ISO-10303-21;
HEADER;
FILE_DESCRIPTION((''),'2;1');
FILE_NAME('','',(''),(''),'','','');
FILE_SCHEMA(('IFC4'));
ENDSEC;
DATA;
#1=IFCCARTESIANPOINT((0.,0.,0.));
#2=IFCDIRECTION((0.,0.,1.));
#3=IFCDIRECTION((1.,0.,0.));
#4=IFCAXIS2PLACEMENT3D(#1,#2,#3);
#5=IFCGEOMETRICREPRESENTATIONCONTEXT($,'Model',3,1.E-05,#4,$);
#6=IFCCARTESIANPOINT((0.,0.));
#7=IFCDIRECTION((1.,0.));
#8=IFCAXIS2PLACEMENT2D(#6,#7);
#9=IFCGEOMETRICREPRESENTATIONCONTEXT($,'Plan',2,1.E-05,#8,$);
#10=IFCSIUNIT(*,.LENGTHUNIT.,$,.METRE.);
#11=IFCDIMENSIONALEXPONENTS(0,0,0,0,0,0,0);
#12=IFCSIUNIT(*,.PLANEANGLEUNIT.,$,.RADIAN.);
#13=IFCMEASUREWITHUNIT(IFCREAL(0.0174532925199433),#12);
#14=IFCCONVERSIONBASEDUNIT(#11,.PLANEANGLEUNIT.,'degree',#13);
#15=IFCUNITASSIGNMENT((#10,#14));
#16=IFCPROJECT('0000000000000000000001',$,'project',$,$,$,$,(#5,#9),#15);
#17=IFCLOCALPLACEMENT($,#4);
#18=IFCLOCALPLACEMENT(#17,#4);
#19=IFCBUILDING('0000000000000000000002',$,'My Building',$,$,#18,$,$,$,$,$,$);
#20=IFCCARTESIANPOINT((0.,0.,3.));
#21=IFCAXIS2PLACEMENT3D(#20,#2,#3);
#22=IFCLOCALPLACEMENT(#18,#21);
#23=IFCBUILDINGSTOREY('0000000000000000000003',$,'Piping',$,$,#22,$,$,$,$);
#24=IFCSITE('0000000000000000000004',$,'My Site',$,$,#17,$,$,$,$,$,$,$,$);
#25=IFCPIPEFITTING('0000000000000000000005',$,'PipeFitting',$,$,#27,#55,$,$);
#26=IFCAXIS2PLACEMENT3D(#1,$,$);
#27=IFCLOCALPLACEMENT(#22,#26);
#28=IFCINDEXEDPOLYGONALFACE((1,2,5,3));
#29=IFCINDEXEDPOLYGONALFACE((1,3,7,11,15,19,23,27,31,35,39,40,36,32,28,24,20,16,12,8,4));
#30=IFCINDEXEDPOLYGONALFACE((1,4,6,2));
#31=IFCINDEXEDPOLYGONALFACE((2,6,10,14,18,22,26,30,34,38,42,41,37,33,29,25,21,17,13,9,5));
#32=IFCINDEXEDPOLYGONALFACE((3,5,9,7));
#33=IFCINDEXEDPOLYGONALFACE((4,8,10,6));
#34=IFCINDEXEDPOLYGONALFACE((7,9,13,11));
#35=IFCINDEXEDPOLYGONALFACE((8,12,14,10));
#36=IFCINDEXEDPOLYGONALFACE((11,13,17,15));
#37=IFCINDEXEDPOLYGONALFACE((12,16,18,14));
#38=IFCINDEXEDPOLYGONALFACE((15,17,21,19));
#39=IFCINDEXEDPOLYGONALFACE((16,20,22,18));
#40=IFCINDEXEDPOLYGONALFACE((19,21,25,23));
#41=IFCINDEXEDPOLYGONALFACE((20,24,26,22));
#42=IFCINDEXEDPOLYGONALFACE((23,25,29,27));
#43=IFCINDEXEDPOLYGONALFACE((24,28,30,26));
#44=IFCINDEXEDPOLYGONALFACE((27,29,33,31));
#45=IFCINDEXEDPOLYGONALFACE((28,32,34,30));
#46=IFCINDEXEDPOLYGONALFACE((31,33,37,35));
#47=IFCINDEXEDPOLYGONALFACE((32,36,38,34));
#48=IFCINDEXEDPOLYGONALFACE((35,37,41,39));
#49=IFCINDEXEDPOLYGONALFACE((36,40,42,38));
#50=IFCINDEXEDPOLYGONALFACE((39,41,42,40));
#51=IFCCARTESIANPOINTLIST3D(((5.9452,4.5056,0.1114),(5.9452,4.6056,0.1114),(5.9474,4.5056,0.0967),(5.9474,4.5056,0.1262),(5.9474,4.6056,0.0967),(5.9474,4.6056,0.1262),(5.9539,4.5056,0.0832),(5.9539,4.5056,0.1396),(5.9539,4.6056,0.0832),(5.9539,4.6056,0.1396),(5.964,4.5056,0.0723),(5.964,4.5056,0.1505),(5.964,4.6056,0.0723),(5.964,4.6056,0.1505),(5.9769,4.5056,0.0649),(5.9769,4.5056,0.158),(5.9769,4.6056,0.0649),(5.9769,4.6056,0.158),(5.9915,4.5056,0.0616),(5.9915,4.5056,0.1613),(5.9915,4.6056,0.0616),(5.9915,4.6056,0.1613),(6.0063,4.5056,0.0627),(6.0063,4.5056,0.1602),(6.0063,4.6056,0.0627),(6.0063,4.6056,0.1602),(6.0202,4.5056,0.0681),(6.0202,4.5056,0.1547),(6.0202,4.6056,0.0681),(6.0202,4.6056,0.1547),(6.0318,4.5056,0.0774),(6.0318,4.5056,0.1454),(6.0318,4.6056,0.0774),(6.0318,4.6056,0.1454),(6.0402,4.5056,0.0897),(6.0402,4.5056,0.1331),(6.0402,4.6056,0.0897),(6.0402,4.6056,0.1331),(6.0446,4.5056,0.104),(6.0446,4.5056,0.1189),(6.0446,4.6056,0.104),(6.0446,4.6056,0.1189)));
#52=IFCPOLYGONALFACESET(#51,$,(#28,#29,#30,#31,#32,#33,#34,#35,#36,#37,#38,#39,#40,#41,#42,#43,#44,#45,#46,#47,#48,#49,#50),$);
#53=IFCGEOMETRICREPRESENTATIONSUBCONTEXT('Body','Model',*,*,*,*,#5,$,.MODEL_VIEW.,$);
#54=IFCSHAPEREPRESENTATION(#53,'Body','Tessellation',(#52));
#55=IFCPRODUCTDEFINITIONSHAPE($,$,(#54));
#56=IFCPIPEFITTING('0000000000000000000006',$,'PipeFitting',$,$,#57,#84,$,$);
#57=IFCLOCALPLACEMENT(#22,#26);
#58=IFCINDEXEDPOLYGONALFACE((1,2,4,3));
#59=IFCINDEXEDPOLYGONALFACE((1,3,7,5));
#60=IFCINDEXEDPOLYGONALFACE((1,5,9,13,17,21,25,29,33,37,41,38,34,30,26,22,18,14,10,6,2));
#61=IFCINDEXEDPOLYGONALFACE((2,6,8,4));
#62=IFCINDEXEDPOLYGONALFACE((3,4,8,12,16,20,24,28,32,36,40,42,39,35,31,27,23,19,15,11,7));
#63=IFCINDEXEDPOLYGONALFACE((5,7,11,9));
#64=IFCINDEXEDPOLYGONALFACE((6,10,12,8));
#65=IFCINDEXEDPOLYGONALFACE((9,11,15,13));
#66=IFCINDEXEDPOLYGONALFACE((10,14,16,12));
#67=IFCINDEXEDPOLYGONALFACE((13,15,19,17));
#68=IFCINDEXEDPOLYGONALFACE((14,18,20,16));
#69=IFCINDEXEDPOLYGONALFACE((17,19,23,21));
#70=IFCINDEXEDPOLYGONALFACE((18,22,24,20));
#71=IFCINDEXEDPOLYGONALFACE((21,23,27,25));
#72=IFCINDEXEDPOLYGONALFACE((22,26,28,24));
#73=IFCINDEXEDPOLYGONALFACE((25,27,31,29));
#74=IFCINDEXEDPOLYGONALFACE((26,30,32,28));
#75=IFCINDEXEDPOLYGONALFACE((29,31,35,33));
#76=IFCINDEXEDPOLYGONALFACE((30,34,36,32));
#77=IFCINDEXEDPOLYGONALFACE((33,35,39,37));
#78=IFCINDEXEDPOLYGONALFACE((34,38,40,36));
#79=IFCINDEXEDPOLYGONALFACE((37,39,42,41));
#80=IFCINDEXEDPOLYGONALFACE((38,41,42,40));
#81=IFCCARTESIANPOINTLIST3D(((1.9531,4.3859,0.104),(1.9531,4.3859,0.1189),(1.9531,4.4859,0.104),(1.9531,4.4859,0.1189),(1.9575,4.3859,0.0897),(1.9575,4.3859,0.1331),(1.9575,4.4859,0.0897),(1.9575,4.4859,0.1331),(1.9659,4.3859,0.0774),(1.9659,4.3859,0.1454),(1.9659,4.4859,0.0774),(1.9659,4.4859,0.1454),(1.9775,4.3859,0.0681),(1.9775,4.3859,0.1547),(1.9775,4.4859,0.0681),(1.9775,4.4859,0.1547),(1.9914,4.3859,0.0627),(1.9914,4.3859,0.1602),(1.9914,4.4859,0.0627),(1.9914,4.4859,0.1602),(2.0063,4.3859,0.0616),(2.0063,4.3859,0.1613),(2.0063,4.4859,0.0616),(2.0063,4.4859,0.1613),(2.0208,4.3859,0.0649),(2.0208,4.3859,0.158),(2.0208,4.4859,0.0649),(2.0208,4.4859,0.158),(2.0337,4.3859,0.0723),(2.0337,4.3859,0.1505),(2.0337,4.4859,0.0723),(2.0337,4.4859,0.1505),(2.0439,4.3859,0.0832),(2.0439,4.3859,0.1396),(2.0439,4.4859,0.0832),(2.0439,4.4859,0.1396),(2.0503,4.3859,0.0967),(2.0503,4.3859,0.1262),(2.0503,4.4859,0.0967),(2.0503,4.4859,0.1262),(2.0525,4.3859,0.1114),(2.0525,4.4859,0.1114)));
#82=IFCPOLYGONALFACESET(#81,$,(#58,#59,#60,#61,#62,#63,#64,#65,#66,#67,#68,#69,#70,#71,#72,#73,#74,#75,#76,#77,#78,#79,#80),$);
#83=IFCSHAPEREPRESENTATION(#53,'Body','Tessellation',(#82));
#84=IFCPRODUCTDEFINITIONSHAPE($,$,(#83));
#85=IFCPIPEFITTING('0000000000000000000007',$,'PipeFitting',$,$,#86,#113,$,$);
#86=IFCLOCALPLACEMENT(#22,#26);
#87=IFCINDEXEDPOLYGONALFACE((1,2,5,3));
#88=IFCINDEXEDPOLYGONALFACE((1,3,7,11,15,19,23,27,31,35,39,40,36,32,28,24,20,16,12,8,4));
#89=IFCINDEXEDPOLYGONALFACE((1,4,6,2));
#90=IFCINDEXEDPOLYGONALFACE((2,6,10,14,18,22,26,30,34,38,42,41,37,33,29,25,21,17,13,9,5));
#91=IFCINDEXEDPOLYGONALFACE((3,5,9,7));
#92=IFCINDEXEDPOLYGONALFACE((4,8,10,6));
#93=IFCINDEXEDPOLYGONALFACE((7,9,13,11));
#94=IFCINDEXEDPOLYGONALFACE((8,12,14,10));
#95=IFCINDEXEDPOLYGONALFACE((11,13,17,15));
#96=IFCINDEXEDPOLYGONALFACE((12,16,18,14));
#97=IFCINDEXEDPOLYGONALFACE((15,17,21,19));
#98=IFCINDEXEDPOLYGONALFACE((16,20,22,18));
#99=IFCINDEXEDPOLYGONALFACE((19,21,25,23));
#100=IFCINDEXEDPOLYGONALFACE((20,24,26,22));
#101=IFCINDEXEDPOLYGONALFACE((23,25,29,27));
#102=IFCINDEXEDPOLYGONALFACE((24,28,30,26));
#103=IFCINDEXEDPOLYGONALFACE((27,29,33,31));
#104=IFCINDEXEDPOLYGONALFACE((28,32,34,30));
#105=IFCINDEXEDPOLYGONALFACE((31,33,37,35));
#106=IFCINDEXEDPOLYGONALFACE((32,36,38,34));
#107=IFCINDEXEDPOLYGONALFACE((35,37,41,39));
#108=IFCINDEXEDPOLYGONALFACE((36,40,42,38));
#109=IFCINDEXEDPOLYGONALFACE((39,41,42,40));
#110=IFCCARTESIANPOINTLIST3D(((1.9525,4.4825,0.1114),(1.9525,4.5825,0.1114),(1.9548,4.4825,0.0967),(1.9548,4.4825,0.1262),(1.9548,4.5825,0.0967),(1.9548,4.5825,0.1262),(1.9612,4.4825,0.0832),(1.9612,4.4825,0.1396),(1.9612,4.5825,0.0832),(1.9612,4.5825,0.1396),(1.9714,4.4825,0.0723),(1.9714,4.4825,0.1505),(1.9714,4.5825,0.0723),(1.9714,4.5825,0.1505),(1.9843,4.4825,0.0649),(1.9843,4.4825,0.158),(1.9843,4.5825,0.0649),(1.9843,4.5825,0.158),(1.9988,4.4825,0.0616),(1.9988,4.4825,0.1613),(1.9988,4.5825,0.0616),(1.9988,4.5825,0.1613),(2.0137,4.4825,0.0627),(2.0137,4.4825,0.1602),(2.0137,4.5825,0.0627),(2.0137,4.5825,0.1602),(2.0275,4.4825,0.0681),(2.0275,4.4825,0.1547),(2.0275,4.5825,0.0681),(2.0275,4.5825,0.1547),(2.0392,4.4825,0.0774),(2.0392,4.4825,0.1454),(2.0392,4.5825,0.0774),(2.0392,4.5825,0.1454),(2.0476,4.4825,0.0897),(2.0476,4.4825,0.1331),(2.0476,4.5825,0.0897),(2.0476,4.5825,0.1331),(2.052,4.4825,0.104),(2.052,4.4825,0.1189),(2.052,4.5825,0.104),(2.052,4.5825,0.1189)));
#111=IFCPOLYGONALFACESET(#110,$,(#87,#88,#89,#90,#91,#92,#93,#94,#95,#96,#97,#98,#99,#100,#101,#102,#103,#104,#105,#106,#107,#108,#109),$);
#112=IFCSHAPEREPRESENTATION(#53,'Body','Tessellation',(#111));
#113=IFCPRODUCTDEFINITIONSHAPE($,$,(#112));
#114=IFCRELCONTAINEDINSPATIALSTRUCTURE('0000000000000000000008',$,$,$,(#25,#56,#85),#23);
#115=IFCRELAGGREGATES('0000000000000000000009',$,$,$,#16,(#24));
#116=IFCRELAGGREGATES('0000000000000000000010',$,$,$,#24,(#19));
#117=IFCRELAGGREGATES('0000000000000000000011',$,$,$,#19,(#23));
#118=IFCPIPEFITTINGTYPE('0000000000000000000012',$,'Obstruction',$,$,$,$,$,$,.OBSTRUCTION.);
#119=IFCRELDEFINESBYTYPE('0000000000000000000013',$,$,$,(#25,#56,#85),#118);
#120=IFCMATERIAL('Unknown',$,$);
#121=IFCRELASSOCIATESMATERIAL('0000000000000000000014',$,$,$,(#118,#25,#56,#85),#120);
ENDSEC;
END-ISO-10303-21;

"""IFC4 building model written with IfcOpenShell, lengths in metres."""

from ifc_helpers import new_model, entity, si_unit, converted_unit, frame, origin_with_axes, origin_2d_with_axis, place, context, subcontext, project, spatial, circle, extrude, material, material_profile, profile_set, profile_usage, type_object, element, save


model = new_model("IFC4")

# Units and contexts
model_context = context("Model", 3, precision=1e-05, world=origin_with_axes())
plan_context = context("Plan", 2, precision=1e-05, world=origin_2d_with_axis())
body_context = subcontext(model_context, "Body", "Model", "MODEL_VIEW")
ifc_project = project(units=[si_unit("LENGTHUNIT", "METRE"), converted_unit("PLANEANGLEUNIT", "degree", entity("IfcReal", 0.0174532925199433), si_unit("PLANEANGLEUNIT", "RADIAN"), dimensions=[0, 0, 0, 0, 0, 0, 0])], contexts=[model_context, plan_context])

# Site, building, storey
site_placement = place(None, origin_with_axes())
site = spatial("IfcSite", under=ifc_project, at=site_placement, Name="My Site")
building_placement = place(site_placement, origin_with_axes())
building = spatial("IfcBuilding", under=site, at=building_placement, Name="My Building")
storey_placement = place(building_placement, frame((0.0, 0.0, 3.0), z_axis=(0.0, 0.0, 1.0), x_axis=(1.0, 0.0, 0.0)))
storey = spatial("IfcBuildingStorey", under=building, at=storey_placement, Name="Piping")

# Shared definitions
ifc_material = material(Name="Unknown")

# Pipe fittings
ifc_material_profile_1 = material_profile(ifc_material, circle(Radius=0.05))
ifc_profile_set_1 = profile_set([ifc_material_profile_1])
pipe_fitting_type_1 = type_object("IfcPipeFittingType", Name="Obstruction", PredefinedType="OBSTRUCTION", material=ifc_profile_set_1)
ifc_profile_usage_1 = profile_usage(ifc_profile_set_1, cardinal=16)
pipe_fitting_1_placement = place(storey_placement, frame((5.9952, 4.5056, 0.1114), z_axis=(0.0, 1.0, 0.0), x_axis=(-1.0, 0.0, 0.0)))
element("IfcPipeFitting", 1, at=pipe_fitting_1_placement, inside=storey, type_object=pipe_fitting_type_1, material=ifc_profile_usage_1, Name="PipeFitting", context=body_context, shape_type="SweptSolid", body=[
    extrude(circle(Radius=0.05), origin_with_axes(), (0.0, 0.0, 1.0), 0.1),
])
ifc_profile_usage_2 = profile_usage(ifc_profile_set_1, cardinal=16)
pipe_fitting_2_placement = place(storey_placement, frame((2.0025, 4.4859, 0.1114), z_axis=(0.0, -1.0, 0.0), x_axis=(1.0, 0.0, 0.0)))
element("IfcPipeFitting", 2, at=pipe_fitting_2_placement, inside=storey, type_object=pipe_fitting_type_1, material=ifc_profile_usage_2, Name="PipeFitting", context=body_context, shape_type="SweptSolid", body=[
    extrude(circle(Radius=0.05), origin_with_axes(), (0.0, 0.0, 1.0), 0.1),
])
ifc_profile_usage_3 = profile_usage(ifc_profile_set_1, cardinal=16)
pipe_fitting_3_placement = place(storey_placement, frame((2.0025, 4.4825, 0.1114), z_axis=(0.0, 1.0, 0.0), x_axis=(-1.0, 0.0, 0.0)))
element("IfcPipeFitting", 3, at=pipe_fitting_3_placement, inside=storey, type_object=pipe_fitting_type_1, material=ifc_profile_usage_3, Name="PipeFitting", context=body_context, shape_type="SweptSolid", body=[
    extrude(circle(Radius=0.05), origin_with_axes(), (0.0, 0.0, 1.0), 0.1),
])

save(model, "model.ifc")
